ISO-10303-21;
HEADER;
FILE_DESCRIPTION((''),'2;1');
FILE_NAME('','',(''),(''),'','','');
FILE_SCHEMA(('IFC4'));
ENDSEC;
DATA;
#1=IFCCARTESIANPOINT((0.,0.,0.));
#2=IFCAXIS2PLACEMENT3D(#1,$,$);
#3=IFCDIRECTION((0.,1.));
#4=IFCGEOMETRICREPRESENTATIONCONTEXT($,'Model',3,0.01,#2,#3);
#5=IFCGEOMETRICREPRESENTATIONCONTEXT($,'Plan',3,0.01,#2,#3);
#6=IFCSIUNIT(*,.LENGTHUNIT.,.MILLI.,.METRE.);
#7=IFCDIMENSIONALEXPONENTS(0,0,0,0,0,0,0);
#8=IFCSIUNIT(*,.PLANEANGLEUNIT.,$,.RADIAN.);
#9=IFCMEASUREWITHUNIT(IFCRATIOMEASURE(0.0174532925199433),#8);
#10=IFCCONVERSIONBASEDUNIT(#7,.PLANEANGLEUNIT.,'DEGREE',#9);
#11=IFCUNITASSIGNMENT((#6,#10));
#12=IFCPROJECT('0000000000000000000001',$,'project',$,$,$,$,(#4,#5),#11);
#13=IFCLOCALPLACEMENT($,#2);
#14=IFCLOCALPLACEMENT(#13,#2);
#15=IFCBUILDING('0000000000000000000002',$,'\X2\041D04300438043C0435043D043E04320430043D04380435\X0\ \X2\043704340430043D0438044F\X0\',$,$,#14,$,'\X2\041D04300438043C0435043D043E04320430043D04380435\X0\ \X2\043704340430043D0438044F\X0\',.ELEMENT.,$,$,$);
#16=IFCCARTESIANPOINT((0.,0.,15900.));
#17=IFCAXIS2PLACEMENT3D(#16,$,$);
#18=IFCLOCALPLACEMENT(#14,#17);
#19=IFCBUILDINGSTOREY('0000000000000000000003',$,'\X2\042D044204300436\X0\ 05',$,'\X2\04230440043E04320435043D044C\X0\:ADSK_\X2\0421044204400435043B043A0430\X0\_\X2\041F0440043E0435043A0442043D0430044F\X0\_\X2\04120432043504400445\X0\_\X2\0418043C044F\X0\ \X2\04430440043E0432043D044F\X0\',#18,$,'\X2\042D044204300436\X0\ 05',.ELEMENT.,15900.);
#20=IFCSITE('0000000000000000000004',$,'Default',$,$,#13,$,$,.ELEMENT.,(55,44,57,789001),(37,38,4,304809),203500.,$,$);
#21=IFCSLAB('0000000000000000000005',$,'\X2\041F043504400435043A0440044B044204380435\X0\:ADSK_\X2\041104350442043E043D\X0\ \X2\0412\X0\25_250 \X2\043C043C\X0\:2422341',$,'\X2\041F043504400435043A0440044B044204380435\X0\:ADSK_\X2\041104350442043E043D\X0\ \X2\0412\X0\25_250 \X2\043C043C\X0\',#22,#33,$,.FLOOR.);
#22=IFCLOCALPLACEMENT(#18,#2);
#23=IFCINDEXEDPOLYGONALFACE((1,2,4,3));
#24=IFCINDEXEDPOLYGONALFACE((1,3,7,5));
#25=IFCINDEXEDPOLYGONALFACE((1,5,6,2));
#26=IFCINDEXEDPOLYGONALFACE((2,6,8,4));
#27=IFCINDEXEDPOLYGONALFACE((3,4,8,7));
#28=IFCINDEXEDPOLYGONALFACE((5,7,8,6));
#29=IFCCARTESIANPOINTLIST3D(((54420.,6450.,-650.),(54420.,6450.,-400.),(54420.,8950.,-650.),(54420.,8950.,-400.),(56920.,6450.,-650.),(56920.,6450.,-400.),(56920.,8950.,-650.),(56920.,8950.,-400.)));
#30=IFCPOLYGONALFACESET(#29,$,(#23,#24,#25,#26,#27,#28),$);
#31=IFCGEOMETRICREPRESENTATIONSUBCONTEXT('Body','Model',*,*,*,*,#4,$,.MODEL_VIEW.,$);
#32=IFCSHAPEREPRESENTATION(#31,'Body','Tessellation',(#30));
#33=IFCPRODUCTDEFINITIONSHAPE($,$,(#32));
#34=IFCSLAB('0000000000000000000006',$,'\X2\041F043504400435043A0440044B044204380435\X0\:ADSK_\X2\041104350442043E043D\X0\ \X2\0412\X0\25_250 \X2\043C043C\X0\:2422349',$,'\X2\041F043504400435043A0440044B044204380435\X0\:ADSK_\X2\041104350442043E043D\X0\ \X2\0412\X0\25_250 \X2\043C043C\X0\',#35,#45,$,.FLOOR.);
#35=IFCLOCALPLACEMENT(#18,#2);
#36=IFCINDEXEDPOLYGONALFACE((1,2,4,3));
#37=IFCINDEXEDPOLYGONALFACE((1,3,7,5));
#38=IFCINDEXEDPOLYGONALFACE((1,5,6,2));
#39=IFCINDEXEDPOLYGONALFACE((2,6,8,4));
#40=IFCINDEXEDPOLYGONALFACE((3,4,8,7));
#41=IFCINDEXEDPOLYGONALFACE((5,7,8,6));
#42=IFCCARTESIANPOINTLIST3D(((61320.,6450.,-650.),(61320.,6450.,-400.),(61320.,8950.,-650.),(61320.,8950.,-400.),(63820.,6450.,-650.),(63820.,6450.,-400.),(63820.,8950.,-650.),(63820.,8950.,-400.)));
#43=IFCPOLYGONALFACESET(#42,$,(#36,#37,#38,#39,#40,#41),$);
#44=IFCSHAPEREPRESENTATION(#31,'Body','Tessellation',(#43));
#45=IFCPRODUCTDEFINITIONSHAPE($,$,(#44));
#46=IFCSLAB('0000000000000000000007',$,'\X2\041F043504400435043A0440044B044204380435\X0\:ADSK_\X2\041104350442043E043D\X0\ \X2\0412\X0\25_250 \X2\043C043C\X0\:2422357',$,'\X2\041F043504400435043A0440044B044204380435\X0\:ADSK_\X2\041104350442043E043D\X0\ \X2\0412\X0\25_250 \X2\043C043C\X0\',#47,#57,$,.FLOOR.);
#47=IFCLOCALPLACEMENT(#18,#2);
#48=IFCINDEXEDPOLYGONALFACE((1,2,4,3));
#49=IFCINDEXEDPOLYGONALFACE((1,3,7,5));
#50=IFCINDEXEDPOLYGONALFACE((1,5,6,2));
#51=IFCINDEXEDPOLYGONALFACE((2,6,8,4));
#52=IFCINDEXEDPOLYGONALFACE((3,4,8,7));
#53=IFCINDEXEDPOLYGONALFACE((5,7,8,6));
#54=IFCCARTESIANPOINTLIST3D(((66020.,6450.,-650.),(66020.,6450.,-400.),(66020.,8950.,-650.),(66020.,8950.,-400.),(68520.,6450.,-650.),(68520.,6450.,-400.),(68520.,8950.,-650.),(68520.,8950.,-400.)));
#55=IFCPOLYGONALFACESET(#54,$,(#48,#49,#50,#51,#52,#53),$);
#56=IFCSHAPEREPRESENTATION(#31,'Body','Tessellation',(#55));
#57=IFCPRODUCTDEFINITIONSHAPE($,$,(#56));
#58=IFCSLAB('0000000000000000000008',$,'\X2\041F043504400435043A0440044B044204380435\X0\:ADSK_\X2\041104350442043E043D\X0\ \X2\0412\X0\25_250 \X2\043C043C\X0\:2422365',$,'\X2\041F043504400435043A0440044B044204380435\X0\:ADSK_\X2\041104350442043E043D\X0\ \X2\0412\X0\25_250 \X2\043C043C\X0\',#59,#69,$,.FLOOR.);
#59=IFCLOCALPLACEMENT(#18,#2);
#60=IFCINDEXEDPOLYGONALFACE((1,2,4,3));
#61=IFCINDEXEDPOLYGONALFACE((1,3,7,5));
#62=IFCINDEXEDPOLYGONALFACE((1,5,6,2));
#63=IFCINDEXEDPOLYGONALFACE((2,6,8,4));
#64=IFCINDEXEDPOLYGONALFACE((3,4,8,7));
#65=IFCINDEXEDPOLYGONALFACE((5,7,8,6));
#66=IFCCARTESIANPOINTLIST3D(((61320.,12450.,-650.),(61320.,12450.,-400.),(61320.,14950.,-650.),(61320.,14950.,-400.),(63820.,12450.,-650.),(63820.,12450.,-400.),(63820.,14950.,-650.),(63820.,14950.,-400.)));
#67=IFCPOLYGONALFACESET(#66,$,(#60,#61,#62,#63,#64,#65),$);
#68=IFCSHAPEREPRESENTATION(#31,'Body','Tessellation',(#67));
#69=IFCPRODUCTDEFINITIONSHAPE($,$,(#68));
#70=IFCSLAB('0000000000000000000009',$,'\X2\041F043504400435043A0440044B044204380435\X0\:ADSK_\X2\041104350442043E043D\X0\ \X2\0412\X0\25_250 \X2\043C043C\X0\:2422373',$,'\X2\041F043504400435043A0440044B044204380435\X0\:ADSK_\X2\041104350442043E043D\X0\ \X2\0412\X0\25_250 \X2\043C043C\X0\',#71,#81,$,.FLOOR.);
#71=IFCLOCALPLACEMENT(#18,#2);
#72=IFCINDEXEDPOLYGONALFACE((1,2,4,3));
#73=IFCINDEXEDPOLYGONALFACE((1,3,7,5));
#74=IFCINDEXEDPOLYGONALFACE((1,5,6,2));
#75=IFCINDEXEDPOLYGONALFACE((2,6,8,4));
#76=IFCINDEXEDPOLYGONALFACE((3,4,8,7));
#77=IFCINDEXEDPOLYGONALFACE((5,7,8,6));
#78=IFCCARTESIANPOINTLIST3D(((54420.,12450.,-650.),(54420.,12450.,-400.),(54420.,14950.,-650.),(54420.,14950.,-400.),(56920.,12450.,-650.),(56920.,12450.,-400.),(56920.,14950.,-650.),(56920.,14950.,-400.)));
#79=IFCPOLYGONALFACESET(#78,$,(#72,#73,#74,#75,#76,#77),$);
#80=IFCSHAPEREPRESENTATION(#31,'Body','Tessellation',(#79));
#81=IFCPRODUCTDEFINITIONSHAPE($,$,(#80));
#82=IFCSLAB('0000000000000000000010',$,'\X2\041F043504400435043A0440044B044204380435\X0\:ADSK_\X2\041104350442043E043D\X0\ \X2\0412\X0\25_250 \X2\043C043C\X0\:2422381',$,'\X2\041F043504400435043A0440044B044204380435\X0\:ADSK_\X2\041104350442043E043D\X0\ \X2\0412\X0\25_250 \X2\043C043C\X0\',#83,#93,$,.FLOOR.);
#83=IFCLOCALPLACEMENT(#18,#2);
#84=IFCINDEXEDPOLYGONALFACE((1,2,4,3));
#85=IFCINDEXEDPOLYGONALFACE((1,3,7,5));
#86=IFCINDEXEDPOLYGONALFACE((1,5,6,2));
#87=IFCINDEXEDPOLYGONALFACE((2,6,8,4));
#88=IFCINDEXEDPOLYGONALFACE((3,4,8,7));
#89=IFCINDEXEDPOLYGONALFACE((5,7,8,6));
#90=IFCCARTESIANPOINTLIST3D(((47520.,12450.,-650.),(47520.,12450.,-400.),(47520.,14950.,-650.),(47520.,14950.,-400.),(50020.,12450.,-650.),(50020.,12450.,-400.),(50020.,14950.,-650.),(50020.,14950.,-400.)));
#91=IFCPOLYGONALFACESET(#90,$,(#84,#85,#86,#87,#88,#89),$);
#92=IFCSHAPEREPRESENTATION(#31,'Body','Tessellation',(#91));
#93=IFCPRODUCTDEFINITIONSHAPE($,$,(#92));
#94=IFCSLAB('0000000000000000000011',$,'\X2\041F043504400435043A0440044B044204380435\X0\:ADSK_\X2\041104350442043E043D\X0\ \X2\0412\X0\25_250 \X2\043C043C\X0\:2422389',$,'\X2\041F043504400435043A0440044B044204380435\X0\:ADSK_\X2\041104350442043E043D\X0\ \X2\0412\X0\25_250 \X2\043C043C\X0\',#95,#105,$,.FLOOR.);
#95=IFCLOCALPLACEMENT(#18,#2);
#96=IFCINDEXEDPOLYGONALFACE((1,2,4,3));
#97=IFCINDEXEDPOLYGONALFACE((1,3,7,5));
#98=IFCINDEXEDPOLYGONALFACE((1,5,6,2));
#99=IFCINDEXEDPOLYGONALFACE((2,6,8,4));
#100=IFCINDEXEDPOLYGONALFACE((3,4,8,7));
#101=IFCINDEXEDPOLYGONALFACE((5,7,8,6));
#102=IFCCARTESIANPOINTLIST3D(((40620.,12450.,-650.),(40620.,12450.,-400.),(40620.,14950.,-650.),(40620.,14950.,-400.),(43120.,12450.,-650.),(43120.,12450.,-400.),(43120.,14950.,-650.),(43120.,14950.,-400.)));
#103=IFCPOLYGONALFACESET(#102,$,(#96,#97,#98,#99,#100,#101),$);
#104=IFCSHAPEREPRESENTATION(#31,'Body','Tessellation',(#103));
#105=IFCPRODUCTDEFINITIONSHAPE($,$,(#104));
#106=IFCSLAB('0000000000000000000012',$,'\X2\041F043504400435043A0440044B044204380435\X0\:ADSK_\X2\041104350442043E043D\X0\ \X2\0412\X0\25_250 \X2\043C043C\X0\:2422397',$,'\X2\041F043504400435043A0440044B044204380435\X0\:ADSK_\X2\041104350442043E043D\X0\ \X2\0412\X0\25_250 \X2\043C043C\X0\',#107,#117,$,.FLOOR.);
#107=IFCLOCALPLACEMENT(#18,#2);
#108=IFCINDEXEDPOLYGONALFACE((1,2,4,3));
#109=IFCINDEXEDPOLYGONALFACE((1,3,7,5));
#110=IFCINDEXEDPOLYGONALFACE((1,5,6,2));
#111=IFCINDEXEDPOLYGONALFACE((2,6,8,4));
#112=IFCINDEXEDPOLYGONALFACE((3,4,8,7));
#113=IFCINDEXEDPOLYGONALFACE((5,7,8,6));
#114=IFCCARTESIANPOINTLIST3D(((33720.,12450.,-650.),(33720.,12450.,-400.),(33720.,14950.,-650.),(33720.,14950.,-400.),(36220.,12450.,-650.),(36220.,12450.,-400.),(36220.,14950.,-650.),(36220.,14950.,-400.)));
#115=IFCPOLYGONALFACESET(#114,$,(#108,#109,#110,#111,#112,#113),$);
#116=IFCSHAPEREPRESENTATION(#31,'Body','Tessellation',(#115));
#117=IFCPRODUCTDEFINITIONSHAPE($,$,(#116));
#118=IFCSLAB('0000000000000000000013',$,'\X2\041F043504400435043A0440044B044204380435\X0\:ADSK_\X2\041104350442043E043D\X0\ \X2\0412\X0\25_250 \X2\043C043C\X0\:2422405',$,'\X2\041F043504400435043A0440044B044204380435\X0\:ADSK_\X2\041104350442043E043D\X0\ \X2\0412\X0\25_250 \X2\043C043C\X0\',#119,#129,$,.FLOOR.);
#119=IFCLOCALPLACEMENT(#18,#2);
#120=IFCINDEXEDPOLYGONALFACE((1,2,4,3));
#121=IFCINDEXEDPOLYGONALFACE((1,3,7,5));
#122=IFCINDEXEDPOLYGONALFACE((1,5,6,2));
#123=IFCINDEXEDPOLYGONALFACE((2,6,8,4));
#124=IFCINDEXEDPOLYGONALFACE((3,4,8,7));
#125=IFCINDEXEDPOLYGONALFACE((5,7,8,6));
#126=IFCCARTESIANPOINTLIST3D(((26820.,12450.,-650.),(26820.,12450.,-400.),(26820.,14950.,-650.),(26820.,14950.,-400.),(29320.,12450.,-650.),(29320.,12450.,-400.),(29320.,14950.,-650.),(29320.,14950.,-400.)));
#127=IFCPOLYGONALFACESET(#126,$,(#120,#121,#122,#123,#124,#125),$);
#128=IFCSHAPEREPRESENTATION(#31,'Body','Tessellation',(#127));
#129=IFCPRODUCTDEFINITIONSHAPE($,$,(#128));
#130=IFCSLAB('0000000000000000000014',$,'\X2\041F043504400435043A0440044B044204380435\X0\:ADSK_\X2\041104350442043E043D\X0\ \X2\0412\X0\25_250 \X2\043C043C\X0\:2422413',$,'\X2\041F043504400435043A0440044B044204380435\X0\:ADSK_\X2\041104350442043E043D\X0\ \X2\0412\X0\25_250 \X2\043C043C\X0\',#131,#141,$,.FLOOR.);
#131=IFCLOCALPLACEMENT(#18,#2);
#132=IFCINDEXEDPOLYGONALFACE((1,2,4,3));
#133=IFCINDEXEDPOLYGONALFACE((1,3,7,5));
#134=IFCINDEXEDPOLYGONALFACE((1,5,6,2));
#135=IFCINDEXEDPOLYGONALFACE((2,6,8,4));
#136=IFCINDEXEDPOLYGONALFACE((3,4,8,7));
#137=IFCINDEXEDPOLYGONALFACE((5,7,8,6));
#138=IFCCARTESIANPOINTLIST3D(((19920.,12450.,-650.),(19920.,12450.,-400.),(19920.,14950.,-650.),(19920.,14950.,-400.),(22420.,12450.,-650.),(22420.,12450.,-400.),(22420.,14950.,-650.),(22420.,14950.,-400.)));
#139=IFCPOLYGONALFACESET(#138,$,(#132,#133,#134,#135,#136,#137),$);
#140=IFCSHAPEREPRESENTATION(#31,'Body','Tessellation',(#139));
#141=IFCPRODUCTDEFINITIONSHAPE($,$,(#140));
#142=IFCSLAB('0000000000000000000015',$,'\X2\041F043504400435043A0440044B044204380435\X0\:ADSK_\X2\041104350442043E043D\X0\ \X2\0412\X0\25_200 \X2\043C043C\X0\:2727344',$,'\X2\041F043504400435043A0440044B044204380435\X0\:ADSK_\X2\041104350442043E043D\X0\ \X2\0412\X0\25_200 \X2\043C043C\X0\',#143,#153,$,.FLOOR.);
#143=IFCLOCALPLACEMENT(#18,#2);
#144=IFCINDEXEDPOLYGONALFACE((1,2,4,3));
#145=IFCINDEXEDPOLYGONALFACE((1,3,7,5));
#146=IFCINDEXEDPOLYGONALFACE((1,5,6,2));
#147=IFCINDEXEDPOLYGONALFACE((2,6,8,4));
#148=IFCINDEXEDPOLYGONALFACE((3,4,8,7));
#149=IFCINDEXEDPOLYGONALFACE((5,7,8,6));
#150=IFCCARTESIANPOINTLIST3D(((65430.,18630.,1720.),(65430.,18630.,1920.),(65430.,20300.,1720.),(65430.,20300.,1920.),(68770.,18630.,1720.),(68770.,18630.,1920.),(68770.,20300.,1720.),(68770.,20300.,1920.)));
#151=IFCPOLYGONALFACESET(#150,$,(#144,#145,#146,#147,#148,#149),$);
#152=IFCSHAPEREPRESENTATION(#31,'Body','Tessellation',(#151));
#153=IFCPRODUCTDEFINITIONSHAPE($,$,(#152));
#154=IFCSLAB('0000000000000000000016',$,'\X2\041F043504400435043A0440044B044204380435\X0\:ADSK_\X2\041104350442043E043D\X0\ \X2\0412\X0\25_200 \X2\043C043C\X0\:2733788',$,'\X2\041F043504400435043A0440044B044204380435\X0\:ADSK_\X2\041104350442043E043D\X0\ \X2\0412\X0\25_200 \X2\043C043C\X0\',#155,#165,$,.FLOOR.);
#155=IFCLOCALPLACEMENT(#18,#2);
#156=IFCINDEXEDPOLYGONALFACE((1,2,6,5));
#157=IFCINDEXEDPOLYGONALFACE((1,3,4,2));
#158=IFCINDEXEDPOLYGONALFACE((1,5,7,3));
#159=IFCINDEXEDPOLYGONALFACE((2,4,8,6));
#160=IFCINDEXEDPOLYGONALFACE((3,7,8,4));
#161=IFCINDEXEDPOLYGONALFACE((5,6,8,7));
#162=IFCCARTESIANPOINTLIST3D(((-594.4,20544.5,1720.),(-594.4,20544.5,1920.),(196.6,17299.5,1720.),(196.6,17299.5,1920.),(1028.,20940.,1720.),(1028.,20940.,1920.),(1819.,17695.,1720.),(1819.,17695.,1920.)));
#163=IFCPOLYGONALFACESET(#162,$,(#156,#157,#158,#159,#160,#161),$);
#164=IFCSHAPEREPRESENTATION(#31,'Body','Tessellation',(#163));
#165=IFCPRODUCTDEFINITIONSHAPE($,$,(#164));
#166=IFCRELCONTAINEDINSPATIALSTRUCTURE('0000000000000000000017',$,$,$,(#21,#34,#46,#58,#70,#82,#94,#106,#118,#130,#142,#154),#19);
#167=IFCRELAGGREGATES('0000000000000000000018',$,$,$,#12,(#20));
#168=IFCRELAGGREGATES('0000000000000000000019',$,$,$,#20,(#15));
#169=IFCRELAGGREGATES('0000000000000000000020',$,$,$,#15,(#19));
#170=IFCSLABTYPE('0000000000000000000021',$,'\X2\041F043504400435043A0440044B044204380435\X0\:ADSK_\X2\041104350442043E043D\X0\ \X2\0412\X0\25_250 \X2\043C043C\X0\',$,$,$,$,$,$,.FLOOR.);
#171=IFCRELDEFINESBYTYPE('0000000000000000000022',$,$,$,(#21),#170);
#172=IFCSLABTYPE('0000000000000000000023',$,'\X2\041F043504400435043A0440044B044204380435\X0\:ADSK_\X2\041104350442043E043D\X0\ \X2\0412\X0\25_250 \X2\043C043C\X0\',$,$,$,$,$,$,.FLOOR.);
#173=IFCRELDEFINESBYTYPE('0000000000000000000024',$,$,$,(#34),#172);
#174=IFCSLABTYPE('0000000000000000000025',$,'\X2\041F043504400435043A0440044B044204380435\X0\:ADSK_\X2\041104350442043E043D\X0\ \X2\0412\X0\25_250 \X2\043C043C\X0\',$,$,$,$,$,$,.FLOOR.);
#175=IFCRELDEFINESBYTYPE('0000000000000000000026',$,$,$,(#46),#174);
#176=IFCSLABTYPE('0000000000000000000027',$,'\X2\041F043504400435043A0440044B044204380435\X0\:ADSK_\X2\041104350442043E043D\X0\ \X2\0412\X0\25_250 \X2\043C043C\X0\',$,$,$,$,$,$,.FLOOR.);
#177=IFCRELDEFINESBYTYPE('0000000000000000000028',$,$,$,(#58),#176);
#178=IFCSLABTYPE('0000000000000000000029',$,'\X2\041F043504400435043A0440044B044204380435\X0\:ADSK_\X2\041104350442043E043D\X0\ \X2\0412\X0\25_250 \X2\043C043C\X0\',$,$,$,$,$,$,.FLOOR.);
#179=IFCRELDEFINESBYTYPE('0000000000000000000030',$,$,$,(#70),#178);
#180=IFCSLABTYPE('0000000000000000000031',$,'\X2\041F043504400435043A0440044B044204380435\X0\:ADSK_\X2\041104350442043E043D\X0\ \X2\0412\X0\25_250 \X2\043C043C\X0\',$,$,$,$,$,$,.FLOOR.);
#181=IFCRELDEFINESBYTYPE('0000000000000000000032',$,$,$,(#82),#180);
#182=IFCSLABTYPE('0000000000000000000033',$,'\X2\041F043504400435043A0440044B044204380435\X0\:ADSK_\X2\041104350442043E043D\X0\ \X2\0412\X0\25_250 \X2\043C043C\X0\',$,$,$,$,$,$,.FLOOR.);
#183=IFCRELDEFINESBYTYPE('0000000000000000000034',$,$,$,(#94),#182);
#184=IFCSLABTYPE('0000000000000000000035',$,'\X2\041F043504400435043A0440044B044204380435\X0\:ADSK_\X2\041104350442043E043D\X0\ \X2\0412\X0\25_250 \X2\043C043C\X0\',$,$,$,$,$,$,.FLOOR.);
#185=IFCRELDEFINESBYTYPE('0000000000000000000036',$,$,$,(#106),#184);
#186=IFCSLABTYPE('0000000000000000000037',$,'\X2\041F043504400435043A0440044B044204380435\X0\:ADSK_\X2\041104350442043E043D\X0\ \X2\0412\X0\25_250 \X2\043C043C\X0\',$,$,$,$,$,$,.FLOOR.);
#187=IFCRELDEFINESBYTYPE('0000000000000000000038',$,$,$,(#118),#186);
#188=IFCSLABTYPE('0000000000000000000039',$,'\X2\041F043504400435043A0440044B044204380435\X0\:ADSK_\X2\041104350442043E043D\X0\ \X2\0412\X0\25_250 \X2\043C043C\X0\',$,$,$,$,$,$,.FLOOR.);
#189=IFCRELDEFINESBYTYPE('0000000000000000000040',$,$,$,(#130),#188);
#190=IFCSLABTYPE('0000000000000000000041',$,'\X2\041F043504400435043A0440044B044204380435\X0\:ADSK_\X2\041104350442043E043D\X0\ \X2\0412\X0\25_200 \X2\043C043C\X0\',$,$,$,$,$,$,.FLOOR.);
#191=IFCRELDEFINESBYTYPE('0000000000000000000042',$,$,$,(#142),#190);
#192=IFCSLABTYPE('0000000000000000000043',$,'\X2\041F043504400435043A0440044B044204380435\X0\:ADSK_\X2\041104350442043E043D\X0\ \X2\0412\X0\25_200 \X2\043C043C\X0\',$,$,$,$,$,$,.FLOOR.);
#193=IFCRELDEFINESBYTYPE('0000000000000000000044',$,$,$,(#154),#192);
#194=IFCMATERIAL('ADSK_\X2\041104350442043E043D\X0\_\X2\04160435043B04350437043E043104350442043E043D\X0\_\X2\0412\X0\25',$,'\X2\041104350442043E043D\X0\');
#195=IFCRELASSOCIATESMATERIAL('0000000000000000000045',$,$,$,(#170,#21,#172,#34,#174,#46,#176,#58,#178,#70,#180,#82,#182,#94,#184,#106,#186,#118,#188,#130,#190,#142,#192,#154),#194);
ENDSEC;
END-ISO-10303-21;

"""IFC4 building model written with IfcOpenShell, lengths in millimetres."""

from ifc_helpers import new_model, entity, si_unit, converted_unit, direction, frame, origin, place, context, subcontext, project, spatial, indexed_curve, outline, extrude, material, type_object, element, save


model = new_model("IFC4")

# Units and contexts
model_context = context("Model", 3, precision=0.01, world=origin(), true_north=direction((0.0, 1.0)))
plan_context = context("Plan", 3, precision=0.01, world=origin(), true_north=direction((0.0, 1.0)))
body_context = subcontext(model_context, "Body", "Model", "MODEL_VIEW")
ifc_project = project(units=[si_unit("LENGTHUNIT", "METRE", prefix="MILLI"), converted_unit("PLANEANGLEUNIT", "DEGREE", entity("IfcRatioMeasure", 0.0174532925199433), si_unit("PLANEANGLEUNIT", "RADIAN"), dimensions=[0, 0, 0, 0, 0, 0, 0])], contexts=[model_context, plan_context])

# Site, building, storey
site_placement = place(None, origin())
site = spatial("IfcSite", under=ifc_project, at=site_placement, Name="Default", CompositionType="ELEMENT", RefLatitude=(55, 44, 57, 789001), RefLongitude=(37, 38, 4, 304809), RefElevation=203500.0)
building_placement = place(site_placement, origin())
building = spatial("IfcBuilding", under=site, at=building_placement, Name="Наименование здания", LongName="Наименование здания", CompositionType="ELEMENT")
storey_placement = place(building_placement, frame((0.0, 0.0, 15900.0)))
storey = spatial("IfcBuildingStorey", under=building, at=storey_placement, Name="Этаж 05", ObjectType="Уровень:ADSK_Стрелка_Проектная_Вверх_Имя уровня", LongName="Этаж 05", CompositionType="ELEMENT", Elevation=15900.0)

# Shared definitions
placement = place(storey_placement, origin())

# Slabs
ifc_material_1 = material(Name="ADSK_Бетон_Железобетон_В25", Category="Бетон")
slab_type_1 = type_object("IfcSlabType", Name="Перекрытие:ADSK_Бетон В25_250 мм", PredefinedType="FLOOR", material=ifc_material_1)
element("IfcSlab", 1, at=placement, inside=storey, type_object=slab_type_1, material=ifc_material_1, Name="Перекрытие:ADSK_Бетон В25_250 мм:2422341", ObjectType="Перекрытие:ADSK_Бетон В25_250 мм", PredefinedType="FLOOR", context=body_context, shape_type="SweptSolid", body=[
    extrude(outline(indexed_curve([(-1250.0, -1250.0), (1250.0, -1250.0), (1250.0, 1250.0), (-1250.0, 1250.0), (-1250.0, -1250.0)], self_intersect=False)), frame((55670.0, 7700.0, -400.0), z_axis=(0.0, 0.0, -1.0), x_axis=(0.0, 1.0, 0.0)), (0.0, 0.0, 1.0), 250.0),
])
slab_type_2 = type_object("IfcSlabType", Name="Перекрытие:ADSK_Бетон В25_250 мм", PredefinedType="FLOOR", material=ifc_material_1)
element("IfcSlab", 2, at=placement, inside=storey, type_object=slab_type_2, material=ifc_material_1, Name="Перекрытие:ADSK_Бетон В25_250 мм:2422349", ObjectType="Перекрытие:ADSK_Бетон В25_250 мм", PredefinedType="FLOOR", context=body_context, shape_type="SweptSolid", body=[
    extrude(outline(indexed_curve([(-1250.0, -1250.0), (1250.0, -1250.0), (1250.0, 1250.0), (-1250.0, 1250.0), (-1250.0, -1250.0)], self_intersect=False)), frame((62570.0, 7700.0, -400.0), z_axis=(0.0, 0.0, -1.0), x_axis=(0.0, 1.0, 0.0)), (0.0, 0.0, 1.0), 250.0),
])
slab_type_3 = type_object("IfcSlabType", Name="Перекрытие:ADSK_Бетон В25_250 мм", PredefinedType="FLOOR", material=ifc_material_1)
element("IfcSlab", 3, at=placement, inside=storey, type_object=slab_type_3, material=ifc_material_1, Name="Перекрытие:ADSK_Бетон В25_250 мм:2422357", ObjectType="Перекрытие:ADSK_Бетон В25_250 мм", PredefinedType="FLOOR", context=body_context, shape_type="SweptSolid", body=[
    extrude(outline(indexed_curve([(-1250.0, -1250.0), (1250.0, -1250.0), (1250.0, 1250.0), (-1250.0, 1250.0), (-1250.0, -1250.0)], self_intersect=False)), frame((67270.0, 7700.0, -400.0), z_axis=(0.0, 0.0, -1.0), x_axis=(0.0, 1.0, 0.0)), (0.0, 0.0, 1.0), 250.0),
])
slab_type_4 = type_object("IfcSlabType", Name="Перекрытие:ADSK_Бетон В25_250 мм", PredefinedType="FLOOR", material=ifc_material_1)
element("IfcSlab", 4, at=placement, inside=storey, type_object=slab_type_4, material=ifc_material_1, Name="Перекрытие:ADSK_Бетон В25_250 мм:2422365", ObjectType="Перекрытие:ADSK_Бетон В25_250 мм", PredefinedType="FLOOR", context=body_context, shape_type="SweptSolid", body=[
    extrude(outline(indexed_curve([(-1250.0, -1250.0), (1250.0, -1250.0), (1250.0, 1250.0), (-1250.0, 1250.0), (-1250.0, -1250.0)], self_intersect=False)), frame((62570.0, 13700.0, -400.0), z_axis=(0.0, 0.0, -1.0), x_axis=(0.0, 1.0, 0.0)), (0.0, 0.0, 1.0), 250.0),
])
slab_type_5 = type_object("IfcSlabType", Name="Перекрытие:ADSK_Бетон В25_250 мм", PredefinedType="FLOOR", material=ifc_material_1)
element("IfcSlab", 5, at=placement, inside=storey, type_object=slab_type_5, material=ifc_material_1, Name="Перекрытие:ADSK_Бетон В25_250 мм:2422373", ObjectType="Перекрытие:ADSK_Бетон В25_250 мм", PredefinedType="FLOOR", context=body_context, shape_type="SweptSolid", body=[
    extrude(outline(indexed_curve([(-1250.0, -1250.0), (1250.0, -1250.0), (1250.0, 1250.0), (-1250.0, 1250.0), (-1250.0, -1250.0)], self_intersect=False)), frame((55670.0, 13700.0, -400.0), z_axis=(0.0, 0.0, -1.0), x_axis=(0.0, 1.0, 0.0)), (0.0, 0.0, 1.0), 250.0),
])
slab_type_6 = type_object("IfcSlabType", Name="Перекрытие:ADSK_Бетон В25_250 мм", PredefinedType="FLOOR", material=ifc_material_1)
element("IfcSlab", 6, at=placement, inside=storey, type_object=slab_type_6, material=ifc_material_1, Name="Перекрытие:ADSK_Бетон В25_250 мм:2422381", ObjectType="Перекрытие:ADSK_Бетон В25_250 мм", PredefinedType="FLOOR", context=body_context, shape_type="SweptSolid", body=[
    extrude(outline(indexed_curve([(-1250.0, -1250.0), (1250.0, -1250.0), (1250.0, 1250.0), (-1250.0, 1250.0), (-1250.0, -1250.0)], self_intersect=False)), frame((48770.0, 13700.0, -400.0), z_axis=(0.0, 0.0, -1.0), x_axis=(0.0, 1.0, 0.0)), (0.0, 0.0, 1.0), 250.0),
])
slab_type_7 = type_object("IfcSlabType", Name="Перекрытие:ADSK_Бетон В25_250 мм", PredefinedType="FLOOR", material=ifc_material_1)
element("IfcSlab", 7, at=placement, inside=storey, type_object=slab_type_7, material=ifc_material_1, Name="Перекрытие:ADSK_Бетон В25_250 мм:2422389", ObjectType="Перекрытие:ADSK_Бетон В25_250 мм", PredefinedType="FLOOR", context=body_context, shape_type="SweptSolid", body=[
    extrude(outline(indexed_curve([(-1250.0, -1250.0), (1250.0, -1250.0), (1250.0, 1250.0), (-1250.0, 1250.0), (-1250.0, -1250.0)], self_intersect=False)), frame((41870.0, 13700.0, -400.0), z_axis=(0.0, 0.0, -1.0), x_axis=(0.0, 1.0, 0.0)), (0.0, 0.0, 1.0), 250.0),
])
slab_type_8 = type_object("IfcSlabType", Name="Перекрытие:ADSK_Бетон В25_250 мм", PredefinedType="FLOOR", material=ifc_material_1)
element("IfcSlab", 8, at=placement, inside=storey, type_object=slab_type_8, material=ifc_material_1, Name="Перекрытие:ADSK_Бетон В25_250 мм:2422397", ObjectType="Перекрытие:ADSK_Бетон В25_250 мм", PredefinedType="FLOOR", context=body_context, shape_type="SweptSolid", body=[
    extrude(outline(indexed_curve([(-1250.0, -1250.0), (1250.0, -1250.0), (1250.0, 1250.0), (-1250.0, 1250.0), (-1250.0, -1250.0)], self_intersect=False)), frame((34970.0, 13700.0, -400.0), z_axis=(0.0, 0.0, -1.0), x_axis=(0.0, 1.0, 0.0)), (0.0, 0.0, 1.0), 250.0),
])
slab_type_9 = type_object("IfcSlabType", Name="Перекрытие:ADSK_Бетон В25_250 мм", PredefinedType="FLOOR", material=ifc_material_1)
element("IfcSlab", 9, at=placement, inside=storey, type_object=slab_type_9, material=ifc_material_1, Name="Перекрытие:ADSK_Бетон В25_250 мм:2422405", ObjectType="Перекрытие:ADSK_Бетон В25_250 мм", PredefinedType="FLOOR", context=body_context, shape_type="SweptSolid", body=[
    extrude(outline(indexed_curve([(-1250.0, -1250.0), (1250.0, -1250.0), (1250.0, 1250.0), (-1250.0, 1250.0), (-1250.0, -1250.0)], self_intersect=False)), frame((28070.0, 13700.0, -400.0), z_axis=(0.0, 0.0, -1.0), x_axis=(0.0, 1.0, 0.0)), (0.0, 0.0, 1.0), 250.0),
])
slab_type_10 = type_object("IfcSlabType", Name="Перекрытие:ADSK_Бетон В25_250 мм", PredefinedType="FLOOR", material=ifc_material_1)
element("IfcSlab", 10, at=placement, inside=storey, type_object=slab_type_10, material=ifc_material_1, Name="Перекрытие:ADSK_Бетон В25_250 мм:2422413", ObjectType="Перекрытие:ADSK_Бетон В25_250 мм", PredefinedType="FLOOR", context=body_context, shape_type="SweptSolid", body=[
    extrude(outline(indexed_curve([(-1250.0, -1250.0), (1250.0, -1250.0), (1250.0, 1250.0), (-1250.0, 1250.0), (-1250.0, -1250.0)], self_intersect=False)), frame((21170.0, 13700.0, -400.0), z_axis=(0.0, 0.0, -1.0), x_axis=(0.0, 1.0, 0.0)), (0.0, 0.0, 1.0), 250.0),
])
slab_type_11 = type_object("IfcSlabType", Name="Перекрытие:ADSK_Бетон В25_200 мм", PredefinedType="FLOOR", material=ifc_material_1)
element("IfcSlab", 11, at=placement, inside=storey, type_object=slab_type_11, material=ifc_material_1, Name="Перекрытие:ADSK_Бетон В25_200 мм:2727344", ObjectType="Перекрытие:ADSK_Бетон В25_200 мм", PredefinedType="FLOOR", context=body_context, shape_type="SweptSolid", body=[
    extrude(outline(indexed_curve([(-835.0, -1670.0), (835.0, -1670.0), (835.0, 1670.0), (-835.0, 1670.0), (-835.0, -1670.0)], self_intersect=False)), frame((67100.0, 19465.0, 1920.0), z_axis=(0.0, 0.0, -1.0), x_axis=(0.0, 1.0, 0.0)), (0.0, 0.0, 1.0), 200.0),
])
slab_type_12 = type_object("IfcSlabType", Name="Перекрытие:ADSK_Бетон В25_200 мм", PredefinedType="FLOOR", material=ifc_material_1)
element("IfcSlab", 12, at=placement, inside=storey, type_object=slab_type_12, material=ifc_material_1, Name="Перекрытие:ADSK_Бетон В25_200 мм:2733788", ObjectType="Перекрытие:ADSK_Бетон В25_200 мм", PredefinedType="FLOOR", context=body_context, shape_type="SweptSolid", body=[
    extrude(outline(indexed_curve([(-835.0, -1670.0), (835.0, -1670.0), (835.0, 1670.0), (-835.0, 1670.0), (-835.0, -1670.0)], self_intersect=False)), frame((612.3, 19119.8, 1920.0), z_axis=(0.0, 0.0, -1.0), x_axis=(0.971552, 0.236826, 0.0)), (0.0, 0.0, 1.0), 200.0),
])

save(model, "model.ifc")
